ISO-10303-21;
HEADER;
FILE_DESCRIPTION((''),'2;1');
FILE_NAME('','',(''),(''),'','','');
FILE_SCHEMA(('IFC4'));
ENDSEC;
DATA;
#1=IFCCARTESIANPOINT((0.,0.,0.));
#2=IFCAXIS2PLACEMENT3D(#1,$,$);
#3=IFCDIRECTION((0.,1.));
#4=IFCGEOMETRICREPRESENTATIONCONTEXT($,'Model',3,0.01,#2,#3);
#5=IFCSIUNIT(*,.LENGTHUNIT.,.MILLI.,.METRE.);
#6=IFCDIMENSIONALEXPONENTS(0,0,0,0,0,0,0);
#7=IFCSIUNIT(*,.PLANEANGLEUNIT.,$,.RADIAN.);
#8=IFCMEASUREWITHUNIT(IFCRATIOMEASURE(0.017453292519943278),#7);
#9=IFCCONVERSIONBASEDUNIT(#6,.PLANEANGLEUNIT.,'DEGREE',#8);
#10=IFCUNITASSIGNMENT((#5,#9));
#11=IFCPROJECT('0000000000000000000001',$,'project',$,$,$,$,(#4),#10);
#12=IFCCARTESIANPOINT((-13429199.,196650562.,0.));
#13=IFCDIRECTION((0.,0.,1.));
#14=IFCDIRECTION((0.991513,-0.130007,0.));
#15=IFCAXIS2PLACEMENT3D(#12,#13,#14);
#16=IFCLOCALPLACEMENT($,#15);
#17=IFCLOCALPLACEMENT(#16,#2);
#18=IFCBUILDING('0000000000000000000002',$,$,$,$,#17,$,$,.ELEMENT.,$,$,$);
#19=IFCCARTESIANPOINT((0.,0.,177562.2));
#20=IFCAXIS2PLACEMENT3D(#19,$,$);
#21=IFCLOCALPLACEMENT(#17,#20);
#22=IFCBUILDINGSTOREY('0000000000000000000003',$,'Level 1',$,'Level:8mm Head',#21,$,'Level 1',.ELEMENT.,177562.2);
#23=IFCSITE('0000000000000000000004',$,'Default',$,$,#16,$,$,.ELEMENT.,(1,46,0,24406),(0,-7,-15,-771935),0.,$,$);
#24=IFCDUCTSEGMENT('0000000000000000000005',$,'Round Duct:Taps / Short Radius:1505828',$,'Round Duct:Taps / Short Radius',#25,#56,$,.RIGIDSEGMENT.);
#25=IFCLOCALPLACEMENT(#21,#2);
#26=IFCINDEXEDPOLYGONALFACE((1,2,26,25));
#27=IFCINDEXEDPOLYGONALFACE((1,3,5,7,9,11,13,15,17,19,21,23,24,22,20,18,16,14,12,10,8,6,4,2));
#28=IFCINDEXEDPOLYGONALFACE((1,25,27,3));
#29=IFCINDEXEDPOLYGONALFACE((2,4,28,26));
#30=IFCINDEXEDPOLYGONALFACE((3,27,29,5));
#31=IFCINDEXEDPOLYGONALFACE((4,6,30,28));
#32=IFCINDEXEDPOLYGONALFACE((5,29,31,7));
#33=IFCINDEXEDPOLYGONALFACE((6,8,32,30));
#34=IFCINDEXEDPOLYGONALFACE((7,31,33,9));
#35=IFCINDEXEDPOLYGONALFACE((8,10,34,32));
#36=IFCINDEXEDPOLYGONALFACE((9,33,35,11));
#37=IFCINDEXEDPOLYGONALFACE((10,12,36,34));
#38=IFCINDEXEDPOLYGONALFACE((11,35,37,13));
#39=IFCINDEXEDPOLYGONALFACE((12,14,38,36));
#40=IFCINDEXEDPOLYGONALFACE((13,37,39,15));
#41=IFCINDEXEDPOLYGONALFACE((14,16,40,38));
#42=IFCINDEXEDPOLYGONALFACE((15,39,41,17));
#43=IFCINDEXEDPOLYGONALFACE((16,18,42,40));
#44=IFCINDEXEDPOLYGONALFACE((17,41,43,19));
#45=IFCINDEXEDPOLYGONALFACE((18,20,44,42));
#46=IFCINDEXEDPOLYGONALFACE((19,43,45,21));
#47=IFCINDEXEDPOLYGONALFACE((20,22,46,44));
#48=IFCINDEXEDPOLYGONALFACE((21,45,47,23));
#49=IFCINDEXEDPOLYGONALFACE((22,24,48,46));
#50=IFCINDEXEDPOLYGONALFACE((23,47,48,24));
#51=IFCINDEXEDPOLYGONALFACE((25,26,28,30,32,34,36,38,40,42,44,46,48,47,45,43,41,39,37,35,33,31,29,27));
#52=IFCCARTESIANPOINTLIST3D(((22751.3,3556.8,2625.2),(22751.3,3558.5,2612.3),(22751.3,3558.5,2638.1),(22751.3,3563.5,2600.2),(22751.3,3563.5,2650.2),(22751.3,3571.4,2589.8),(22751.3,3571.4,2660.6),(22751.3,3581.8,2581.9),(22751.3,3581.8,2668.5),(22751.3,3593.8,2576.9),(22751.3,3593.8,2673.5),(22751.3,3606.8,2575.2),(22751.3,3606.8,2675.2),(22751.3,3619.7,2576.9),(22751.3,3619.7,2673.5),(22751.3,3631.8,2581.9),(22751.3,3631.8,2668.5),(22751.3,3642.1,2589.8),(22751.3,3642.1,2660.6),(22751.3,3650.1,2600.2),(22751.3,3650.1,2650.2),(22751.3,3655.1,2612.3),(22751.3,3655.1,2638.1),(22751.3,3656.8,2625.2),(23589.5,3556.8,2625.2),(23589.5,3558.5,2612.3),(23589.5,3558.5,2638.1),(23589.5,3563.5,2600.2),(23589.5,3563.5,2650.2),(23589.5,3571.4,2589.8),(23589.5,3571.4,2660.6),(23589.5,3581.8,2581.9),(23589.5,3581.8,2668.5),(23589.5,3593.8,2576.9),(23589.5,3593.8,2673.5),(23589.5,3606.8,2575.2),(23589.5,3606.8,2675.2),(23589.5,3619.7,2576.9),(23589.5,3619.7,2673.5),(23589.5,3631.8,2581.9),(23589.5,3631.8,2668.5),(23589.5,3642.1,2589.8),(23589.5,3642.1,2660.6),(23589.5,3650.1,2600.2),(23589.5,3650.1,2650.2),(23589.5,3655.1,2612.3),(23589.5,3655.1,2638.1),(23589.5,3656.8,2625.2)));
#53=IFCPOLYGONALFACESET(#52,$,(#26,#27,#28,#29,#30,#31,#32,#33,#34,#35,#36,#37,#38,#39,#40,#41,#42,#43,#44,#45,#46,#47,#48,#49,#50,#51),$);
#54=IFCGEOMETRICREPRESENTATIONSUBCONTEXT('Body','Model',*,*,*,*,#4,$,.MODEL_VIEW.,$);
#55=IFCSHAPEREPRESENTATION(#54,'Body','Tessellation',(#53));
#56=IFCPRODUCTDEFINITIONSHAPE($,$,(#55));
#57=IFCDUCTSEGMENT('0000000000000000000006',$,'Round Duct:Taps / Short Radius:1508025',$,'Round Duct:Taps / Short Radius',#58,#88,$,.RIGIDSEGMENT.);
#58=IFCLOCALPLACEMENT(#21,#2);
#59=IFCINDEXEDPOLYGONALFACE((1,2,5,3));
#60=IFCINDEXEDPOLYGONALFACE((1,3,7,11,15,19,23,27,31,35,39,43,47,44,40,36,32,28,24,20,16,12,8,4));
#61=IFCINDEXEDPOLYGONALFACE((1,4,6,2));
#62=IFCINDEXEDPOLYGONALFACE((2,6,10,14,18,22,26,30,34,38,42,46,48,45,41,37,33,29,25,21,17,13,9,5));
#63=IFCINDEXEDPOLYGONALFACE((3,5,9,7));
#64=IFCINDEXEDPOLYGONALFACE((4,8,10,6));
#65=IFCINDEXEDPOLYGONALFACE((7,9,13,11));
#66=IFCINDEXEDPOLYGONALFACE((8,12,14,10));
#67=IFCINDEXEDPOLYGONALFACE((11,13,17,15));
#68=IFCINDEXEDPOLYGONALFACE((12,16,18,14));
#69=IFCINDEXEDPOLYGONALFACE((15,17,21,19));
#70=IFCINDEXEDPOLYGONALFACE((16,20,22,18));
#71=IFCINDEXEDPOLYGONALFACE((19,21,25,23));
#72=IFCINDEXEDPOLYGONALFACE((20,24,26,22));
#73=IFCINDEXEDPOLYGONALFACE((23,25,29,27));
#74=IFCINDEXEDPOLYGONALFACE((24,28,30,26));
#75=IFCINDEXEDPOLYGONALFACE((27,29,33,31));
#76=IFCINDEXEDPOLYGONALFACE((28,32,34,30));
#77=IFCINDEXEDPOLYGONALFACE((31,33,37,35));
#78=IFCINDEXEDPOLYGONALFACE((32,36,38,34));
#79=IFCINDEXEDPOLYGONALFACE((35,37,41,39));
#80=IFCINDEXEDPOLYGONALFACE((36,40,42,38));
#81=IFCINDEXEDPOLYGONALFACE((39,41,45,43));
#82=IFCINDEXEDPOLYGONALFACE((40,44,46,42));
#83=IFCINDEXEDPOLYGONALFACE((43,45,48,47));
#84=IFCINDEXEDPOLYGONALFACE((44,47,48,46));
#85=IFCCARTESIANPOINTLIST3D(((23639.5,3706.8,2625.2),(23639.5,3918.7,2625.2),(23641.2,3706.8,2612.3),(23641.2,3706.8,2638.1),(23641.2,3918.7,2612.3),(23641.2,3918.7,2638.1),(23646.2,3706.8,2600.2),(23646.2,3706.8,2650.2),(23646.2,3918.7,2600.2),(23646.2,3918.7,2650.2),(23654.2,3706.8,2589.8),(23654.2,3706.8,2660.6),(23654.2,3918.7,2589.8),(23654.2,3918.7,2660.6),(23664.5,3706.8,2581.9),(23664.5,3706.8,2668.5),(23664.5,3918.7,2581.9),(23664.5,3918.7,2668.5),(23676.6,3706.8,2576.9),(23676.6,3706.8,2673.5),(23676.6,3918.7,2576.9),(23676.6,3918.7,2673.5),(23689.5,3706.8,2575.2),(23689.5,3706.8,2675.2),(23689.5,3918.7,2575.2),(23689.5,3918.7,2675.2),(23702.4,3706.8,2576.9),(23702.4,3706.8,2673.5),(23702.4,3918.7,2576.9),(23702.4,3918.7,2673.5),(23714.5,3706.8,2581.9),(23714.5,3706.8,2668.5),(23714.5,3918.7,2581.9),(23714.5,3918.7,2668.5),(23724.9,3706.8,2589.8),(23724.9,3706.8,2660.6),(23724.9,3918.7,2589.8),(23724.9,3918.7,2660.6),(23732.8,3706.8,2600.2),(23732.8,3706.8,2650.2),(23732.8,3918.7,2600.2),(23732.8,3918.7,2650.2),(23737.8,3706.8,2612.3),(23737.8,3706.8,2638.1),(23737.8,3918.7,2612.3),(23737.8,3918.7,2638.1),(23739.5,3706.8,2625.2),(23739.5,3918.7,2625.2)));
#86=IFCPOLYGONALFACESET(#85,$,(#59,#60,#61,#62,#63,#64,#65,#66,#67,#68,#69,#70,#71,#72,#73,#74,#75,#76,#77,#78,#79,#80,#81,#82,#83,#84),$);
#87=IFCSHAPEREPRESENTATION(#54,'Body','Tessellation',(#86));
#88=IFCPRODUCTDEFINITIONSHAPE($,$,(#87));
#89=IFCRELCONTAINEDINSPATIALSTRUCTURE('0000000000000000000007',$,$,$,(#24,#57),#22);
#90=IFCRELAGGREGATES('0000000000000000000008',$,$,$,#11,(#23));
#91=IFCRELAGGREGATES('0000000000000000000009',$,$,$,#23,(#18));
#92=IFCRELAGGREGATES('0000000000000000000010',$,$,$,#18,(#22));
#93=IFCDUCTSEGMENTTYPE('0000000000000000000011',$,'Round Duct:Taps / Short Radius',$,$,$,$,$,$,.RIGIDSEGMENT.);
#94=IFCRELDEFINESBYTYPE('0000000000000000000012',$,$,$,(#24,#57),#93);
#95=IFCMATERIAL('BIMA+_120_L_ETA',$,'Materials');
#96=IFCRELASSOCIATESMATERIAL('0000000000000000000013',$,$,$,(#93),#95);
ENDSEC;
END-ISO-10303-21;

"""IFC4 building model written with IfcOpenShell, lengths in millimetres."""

from ifc_helpers import new_model, entity, si_unit, converted_unit, direction, frame, origin, place, context, subcontext, project, spatial, arc, indexed_curve, outline, extrude, material, type_object, element, save


model = new_model("IFC4")

# Units and contexts
model_context = context("Model", 3, precision=0.01, world=origin(), true_north=direction((0.0, 1.0)))
body_context = subcontext(model_context, "Body", "Model", "MODEL_VIEW")
ifc_project = project(units=[si_unit("LENGTHUNIT", "METRE", prefix="MILLI"), converted_unit("PLANEANGLEUNIT", "DEGREE", entity("IfcRatioMeasure", 0.017453292519943278), si_unit("PLANEANGLEUNIT", "RADIAN"), dimensions=[0, 0, 0, 0, 0, 0, 0])], contexts=[model_context])

# Site, building, storey
site_placement = place(None, frame((-13429199.0, 196650562.0, 0.0), z_axis=(0.0, 0.0, 1.0), x_axis=(0.991513, -0.130007, 0.0)))
site = spatial("IfcSite", under=ifc_project, at=site_placement, Name="Default", CompositionType="ELEMENT", RefLatitude=(1, 46, 0, 24406), RefLongitude=(0, -7, -15, -771935), RefElevation=0.0)
building_placement = place(site_placement, origin())
building = spatial("IfcBuilding", under=site, at=building_placement, CompositionType="ELEMENT")
storey_placement = place(building_placement, frame((0.0, 0.0, 177562.2)))
storey = spatial("IfcBuildingStorey", under=building, at=storey_placement, Name="Level 1", ObjectType="Level:8mm Head", LongName="Level 1", CompositionType="ELEMENT", Elevation=177562.2)

# Duct segments
ifc_material_1 = material(Name="BIMA+_120_L_ETA", Category="Materials")
duct_segment_type = type_object("IfcDuctSegmentType", Name="Round Duct:Taps / Short Radius", PredefinedType="RIGIDSEGMENT", material=ifc_material_1)
duct_segment_1_placement = place(storey_placement, frame((22751.3, 3555.2, 2573.6)))
element("IfcDuctSegment", 1, at=duct_segment_1_placement, inside=storey, type_object=duct_segment_type, Name="Round Duct:Taps / Short Radius:1505828", ObjectType="Round Duct:Taps / Short Radius", PredefinedType="RIGIDSEGMENT", context=body_context, shape_type="SweptSolid", body=[
    extrude(outline(indexed_curve([(50.0, 0.0), (35.4, 35.4), (0.0, 50.0), (-35.4, 35.4), (-50.0, 0.0), (-35.4, -35.4), (0.0, -50.0), (35.4, -35.4)], segments=[arc(1, 2, 3), arc(3, 4, 5), arc(5, 6, 7), arc(7, 8, 1)], self_intersect=False)), frame((0.0, 51.6, 51.6), z_axis=(1.0, 0.0, 0.0), x_axis=(0.0, -1.0, 0.0)), (0.0, 0.0, 1.0), 838.2),
])
duct_segment_2_placement = place(storey_placement, frame((23637.9, 3706.8, 2573.6)))
element("IfcDuctSegment", 2, at=duct_segment_2_placement, inside=storey, type_object=duct_segment_type, Name="Round Duct:Taps / Short Radius:1508025", ObjectType="Round Duct:Taps / Short Radius", PredefinedType="RIGIDSEGMENT", context=body_context, shape_type="SweptSolid", body=[
    extrude(outline(indexed_curve([(50.0, 0.0), (35.4, 35.4), (0.0, 50.0), (-35.4, 35.4), (-50.0, 0.0), (-35.4, -35.4), (0.0, -50.0), (35.4, -35.4)], segments=[arc(1, 2, 3), arc(3, 4, 5), arc(5, 6, 7), arc(7, 8, 1)], self_intersect=False)), frame((51.6, 0.0, 51.6), z_axis=(0.0, 1.0, 0.0), x_axis=(-1.0, 0.0, 0.0)), (0.0, 0.0, 1.0), 212.0),
])

save(model, "model.ifc")
